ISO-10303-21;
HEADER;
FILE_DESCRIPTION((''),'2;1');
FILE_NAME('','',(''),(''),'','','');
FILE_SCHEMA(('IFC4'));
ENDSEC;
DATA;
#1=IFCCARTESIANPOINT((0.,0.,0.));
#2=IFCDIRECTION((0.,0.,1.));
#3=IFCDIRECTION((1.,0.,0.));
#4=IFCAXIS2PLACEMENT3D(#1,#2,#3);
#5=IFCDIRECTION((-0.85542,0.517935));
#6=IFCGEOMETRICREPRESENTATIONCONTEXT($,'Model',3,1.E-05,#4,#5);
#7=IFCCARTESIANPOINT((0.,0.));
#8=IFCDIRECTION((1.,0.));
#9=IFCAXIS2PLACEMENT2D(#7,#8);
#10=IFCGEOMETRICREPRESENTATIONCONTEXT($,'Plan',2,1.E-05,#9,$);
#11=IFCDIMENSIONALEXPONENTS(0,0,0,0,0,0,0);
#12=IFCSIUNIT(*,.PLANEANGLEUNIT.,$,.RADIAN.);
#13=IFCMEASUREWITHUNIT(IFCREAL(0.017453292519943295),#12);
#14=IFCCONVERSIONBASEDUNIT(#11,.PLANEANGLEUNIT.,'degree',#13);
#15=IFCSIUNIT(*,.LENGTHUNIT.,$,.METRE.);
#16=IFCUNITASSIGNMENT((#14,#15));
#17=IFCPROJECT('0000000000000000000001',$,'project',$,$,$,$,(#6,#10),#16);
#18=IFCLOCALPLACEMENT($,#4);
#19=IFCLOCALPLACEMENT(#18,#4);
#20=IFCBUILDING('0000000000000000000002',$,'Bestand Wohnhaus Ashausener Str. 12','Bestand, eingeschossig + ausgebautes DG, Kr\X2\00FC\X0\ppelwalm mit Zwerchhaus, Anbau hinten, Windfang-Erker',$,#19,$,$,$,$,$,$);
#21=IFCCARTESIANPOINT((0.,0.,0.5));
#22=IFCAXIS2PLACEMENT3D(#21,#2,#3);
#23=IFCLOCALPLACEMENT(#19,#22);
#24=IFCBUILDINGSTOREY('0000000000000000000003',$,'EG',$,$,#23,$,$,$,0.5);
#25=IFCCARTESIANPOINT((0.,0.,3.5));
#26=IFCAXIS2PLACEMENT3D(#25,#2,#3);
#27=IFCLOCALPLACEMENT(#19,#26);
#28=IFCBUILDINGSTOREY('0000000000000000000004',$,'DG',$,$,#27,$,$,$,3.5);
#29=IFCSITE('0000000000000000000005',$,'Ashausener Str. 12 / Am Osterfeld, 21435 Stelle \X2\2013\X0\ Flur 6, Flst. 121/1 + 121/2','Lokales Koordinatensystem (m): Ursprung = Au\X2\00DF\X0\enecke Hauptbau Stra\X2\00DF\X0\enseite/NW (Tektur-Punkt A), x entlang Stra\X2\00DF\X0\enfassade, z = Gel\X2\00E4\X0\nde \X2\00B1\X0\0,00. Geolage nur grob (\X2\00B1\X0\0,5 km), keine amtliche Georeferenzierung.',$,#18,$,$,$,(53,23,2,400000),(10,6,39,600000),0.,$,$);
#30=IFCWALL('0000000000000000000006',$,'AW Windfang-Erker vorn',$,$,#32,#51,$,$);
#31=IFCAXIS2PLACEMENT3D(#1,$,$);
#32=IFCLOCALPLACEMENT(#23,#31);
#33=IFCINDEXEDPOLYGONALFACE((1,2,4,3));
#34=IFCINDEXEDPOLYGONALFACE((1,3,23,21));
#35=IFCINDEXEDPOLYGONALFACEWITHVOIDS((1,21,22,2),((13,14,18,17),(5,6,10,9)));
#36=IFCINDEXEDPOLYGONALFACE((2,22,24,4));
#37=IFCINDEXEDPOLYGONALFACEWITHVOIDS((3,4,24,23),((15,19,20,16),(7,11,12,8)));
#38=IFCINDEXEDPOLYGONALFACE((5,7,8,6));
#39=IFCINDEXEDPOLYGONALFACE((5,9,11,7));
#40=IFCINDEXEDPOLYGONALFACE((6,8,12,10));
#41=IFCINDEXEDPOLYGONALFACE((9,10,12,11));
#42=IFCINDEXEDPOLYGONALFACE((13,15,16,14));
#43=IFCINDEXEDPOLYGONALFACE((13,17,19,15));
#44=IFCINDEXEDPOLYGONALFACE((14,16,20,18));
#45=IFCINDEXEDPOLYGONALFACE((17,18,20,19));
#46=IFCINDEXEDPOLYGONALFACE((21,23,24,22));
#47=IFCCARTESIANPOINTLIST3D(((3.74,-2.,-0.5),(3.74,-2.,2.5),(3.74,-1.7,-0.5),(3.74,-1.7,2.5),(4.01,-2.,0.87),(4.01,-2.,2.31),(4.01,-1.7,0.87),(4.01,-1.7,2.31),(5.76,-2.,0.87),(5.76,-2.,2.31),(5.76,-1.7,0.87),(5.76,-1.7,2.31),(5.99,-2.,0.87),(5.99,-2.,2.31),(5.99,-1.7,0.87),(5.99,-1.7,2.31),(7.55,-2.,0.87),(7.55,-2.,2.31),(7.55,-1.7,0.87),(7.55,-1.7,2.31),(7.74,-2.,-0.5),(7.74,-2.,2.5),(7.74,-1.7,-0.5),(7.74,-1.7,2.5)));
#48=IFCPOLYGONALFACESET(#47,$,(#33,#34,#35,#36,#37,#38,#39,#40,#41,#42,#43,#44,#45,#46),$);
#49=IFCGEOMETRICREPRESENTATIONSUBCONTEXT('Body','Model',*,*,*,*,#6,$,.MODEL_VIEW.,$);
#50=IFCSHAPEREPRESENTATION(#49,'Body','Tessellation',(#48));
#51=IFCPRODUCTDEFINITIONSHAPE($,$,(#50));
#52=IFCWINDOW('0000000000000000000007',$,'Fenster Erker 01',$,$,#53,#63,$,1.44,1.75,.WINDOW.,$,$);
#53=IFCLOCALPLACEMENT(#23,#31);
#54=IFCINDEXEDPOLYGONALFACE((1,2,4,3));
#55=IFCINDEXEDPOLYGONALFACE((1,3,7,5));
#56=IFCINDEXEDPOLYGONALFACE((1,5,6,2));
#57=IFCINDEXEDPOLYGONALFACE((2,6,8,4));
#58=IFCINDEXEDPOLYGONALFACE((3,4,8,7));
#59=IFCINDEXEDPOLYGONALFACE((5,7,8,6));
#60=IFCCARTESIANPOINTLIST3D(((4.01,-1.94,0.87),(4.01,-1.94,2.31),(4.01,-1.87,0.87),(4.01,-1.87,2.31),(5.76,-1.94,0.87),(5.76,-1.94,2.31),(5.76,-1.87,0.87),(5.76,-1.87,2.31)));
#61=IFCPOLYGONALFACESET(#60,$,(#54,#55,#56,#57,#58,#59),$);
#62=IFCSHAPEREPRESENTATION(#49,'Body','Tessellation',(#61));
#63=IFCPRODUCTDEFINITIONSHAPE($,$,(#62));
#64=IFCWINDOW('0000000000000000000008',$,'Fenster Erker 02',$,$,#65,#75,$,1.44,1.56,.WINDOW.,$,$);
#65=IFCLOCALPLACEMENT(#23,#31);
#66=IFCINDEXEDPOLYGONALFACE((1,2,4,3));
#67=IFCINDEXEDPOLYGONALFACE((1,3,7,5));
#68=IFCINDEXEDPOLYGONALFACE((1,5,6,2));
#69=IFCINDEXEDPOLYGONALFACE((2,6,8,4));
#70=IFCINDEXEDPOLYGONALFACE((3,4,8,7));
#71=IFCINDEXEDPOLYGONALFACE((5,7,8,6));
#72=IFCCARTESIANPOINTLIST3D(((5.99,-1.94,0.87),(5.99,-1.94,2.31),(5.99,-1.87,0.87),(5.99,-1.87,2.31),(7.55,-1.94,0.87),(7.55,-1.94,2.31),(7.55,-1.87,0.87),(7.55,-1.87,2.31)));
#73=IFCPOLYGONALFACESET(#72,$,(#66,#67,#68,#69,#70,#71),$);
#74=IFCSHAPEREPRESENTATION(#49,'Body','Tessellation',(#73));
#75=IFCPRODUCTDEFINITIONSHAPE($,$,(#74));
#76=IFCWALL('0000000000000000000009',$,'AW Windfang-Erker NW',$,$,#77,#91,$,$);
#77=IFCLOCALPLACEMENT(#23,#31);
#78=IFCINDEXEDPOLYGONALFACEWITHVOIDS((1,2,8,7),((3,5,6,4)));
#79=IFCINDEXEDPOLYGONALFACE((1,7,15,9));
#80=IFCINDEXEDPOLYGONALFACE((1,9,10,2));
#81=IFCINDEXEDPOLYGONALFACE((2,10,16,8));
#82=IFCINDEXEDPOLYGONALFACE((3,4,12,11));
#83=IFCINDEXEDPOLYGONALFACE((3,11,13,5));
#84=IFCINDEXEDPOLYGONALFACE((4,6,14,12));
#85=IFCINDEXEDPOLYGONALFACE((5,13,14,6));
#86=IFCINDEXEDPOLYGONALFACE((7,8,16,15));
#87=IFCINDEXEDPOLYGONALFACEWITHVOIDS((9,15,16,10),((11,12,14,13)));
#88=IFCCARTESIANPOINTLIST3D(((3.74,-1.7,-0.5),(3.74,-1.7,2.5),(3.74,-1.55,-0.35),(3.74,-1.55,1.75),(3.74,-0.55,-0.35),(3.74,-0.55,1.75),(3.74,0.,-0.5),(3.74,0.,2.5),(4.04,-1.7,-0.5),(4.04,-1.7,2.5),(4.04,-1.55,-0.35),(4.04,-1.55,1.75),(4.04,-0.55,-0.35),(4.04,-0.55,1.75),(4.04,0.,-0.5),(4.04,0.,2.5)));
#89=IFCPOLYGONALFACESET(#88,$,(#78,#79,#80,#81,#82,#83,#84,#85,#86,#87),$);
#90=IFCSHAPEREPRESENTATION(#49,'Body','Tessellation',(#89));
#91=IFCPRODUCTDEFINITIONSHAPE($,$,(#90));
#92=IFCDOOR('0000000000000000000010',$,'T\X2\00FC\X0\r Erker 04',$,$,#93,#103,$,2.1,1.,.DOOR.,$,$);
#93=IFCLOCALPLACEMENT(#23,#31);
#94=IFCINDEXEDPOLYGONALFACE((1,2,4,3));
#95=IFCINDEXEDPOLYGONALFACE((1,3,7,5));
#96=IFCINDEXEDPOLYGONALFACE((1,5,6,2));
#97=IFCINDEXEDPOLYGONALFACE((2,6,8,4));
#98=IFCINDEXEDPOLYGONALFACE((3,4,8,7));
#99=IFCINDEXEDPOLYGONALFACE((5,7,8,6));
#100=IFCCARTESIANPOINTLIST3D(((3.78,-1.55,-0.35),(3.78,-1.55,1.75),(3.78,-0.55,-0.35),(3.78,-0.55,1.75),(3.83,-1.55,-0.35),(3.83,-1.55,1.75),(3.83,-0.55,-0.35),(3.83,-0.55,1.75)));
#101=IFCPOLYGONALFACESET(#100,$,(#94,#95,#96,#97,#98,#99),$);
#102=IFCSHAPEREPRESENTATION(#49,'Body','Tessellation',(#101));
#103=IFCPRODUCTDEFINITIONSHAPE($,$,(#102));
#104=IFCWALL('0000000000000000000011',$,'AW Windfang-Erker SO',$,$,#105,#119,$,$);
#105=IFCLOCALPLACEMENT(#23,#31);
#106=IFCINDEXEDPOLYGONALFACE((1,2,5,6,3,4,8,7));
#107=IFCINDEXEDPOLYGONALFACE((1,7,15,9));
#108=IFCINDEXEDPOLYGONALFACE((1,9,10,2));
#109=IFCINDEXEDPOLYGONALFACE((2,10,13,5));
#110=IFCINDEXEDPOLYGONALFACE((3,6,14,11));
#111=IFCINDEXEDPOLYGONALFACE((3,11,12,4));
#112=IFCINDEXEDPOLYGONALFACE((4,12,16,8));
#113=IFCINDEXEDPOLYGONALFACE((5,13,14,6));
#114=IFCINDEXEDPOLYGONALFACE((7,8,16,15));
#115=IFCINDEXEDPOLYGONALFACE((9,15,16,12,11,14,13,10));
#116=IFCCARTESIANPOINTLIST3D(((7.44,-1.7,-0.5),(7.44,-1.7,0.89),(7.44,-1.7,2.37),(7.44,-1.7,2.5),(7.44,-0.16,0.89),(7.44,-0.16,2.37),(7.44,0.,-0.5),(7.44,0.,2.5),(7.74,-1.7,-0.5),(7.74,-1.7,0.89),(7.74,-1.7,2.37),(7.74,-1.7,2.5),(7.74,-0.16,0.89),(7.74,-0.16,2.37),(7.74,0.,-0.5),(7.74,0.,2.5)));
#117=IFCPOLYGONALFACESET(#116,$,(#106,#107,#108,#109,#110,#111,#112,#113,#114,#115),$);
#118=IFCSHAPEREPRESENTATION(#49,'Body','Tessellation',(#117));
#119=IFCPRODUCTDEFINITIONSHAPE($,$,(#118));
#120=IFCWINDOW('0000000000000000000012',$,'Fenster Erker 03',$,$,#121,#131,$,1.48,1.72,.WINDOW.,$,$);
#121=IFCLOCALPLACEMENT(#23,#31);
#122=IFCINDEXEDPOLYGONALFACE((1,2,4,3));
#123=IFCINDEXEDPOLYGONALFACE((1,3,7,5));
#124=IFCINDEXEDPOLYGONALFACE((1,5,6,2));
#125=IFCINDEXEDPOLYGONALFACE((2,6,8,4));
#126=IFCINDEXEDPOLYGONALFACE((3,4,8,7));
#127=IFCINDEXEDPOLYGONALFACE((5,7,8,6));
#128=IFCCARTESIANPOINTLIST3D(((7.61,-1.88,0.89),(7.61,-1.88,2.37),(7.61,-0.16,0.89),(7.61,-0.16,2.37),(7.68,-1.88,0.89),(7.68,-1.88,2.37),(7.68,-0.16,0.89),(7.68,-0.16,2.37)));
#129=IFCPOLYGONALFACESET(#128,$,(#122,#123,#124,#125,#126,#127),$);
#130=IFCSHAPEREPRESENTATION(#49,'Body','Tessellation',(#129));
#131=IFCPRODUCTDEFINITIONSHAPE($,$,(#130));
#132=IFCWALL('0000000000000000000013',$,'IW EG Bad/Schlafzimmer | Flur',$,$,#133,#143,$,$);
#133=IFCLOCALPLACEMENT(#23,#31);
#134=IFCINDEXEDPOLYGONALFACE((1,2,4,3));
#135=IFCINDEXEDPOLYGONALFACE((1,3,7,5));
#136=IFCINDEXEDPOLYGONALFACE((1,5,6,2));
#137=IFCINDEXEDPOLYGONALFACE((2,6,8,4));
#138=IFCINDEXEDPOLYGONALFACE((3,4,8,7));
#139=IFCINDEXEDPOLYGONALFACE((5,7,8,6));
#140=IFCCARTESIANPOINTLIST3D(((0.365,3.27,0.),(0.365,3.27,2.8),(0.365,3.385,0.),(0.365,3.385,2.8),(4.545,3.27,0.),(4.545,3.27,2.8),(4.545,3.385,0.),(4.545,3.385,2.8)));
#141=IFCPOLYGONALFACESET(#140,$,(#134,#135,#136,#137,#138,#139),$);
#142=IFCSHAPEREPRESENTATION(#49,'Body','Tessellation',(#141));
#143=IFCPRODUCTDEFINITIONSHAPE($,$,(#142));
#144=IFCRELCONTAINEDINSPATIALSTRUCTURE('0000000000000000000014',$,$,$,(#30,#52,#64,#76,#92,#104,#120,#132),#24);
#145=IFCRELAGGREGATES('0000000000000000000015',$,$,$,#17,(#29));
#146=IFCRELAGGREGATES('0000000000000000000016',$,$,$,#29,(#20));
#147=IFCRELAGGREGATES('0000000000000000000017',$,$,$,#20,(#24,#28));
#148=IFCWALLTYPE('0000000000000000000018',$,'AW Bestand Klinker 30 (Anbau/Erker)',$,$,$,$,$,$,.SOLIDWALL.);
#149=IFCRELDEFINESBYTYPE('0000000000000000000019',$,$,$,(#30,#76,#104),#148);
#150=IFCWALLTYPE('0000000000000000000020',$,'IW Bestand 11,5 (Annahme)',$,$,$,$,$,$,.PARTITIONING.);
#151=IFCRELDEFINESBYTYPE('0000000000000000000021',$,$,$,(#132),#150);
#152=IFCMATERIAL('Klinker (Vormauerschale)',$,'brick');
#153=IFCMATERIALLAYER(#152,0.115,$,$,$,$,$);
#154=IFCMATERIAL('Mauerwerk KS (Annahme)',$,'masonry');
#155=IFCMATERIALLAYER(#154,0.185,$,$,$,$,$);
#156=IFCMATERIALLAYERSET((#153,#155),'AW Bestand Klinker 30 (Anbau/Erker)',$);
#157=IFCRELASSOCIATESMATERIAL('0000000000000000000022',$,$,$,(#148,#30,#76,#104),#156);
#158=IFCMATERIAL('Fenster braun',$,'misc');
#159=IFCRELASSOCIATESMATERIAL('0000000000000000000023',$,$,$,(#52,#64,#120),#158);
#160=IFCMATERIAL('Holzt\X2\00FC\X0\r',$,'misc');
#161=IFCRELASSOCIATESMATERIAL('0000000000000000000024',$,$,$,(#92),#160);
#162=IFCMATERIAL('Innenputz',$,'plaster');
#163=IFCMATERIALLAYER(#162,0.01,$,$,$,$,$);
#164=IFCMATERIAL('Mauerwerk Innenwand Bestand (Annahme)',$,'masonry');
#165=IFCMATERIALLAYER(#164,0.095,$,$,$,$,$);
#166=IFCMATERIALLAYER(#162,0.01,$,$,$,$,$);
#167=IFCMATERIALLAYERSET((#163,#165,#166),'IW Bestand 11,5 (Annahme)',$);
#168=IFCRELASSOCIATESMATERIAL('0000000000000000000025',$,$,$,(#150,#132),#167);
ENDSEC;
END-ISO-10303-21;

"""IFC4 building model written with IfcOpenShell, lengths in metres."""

from ifc_helpers import new_model, entity, si_unit, converted_unit, direction, frame, origin_with_axes, origin_2d_with_axis, place, context, subcontext, project, spatial, indexed_curve, outline, extrude, material, layer, layer_set, layer_usage, type_object, element, fill, save


model = new_model("IFC4")

# Units and contexts
model_context = context("Model", 3, precision=1e-05, world=origin_with_axes(), true_north=direction((-0.85542, 0.517935)))
plan_context = context("Plan", 2, precision=1e-05, world=origin_2d_with_axis())
body_context = subcontext(model_context, "Body", "Model", "MODEL_VIEW")
ifc_project = project(units=[converted_unit("PLANEANGLEUNIT", "degree", entity("IfcReal", 0.017453292519943295), si_unit("PLANEANGLEUNIT", "RADIAN"), dimensions=[0, 0, 0, 0, 0, 0, 0]), si_unit("LENGTHUNIT", "METRE")], contexts=[model_context, plan_context])

# Site, building, storey
site_placement = place(None, origin_with_axes())
site = spatial("IfcSite", under=ifc_project, at=site_placement, Name="Ashausener Str. 12 / Am Osterfeld, 21435 Stelle – Flur 6, Flst. 121/1 + 121/2", Description="Lokales Koordinatensystem (m): Ursprung = Außenecke Hauptbau Straßenseite/NW (Tektur-Punkt A), x entlang Straßenfassade, z = Gelände ±0,00. Geolage nur grob (±0,5 km), keine amtliche Georeferenzierung.", RefLatitude=(53, 23, 2, 400000), RefLongitude=(10, 6, 39, 600000), RefElevation=0.0)
building_placement = place(site_placement, origin_with_axes())
building = spatial("IfcBuilding", under=site, at=building_placement, Name="Bestand Wohnhaus Ashausener Str. 12", Description="Bestand, eingeschossig + ausgebautes DG, Krüppelwalm mit Zwerchhaus, Anbau hinten, Windfang-Erker")
storey_1_placement = place(building_placement, frame((0.0, 0.0, 0.5), z_axis=(0.0, 0.0, 1.0), x_axis=(1.0, 0.0, 0.0)))
storey_1 = spatial("IfcBuildingStorey", under=building, at=storey_1_placement, Name="EG", Elevation=0.5)

# Shared definitions
ifc_material_1 = material(Name="Klinker (Vormauerschale)", Category="brick")
ifc_material_2 = material(Name="Mauerwerk KS (Annahme)", Category="masonry")

# Shared definitions
storey_2_placement = place(building_placement, frame((0.0, 0.0, 3.5), z_axis=(0.0, 0.0, 1.0), x_axis=(1.0, 0.0, 0.0)))
storey_2 = spatial("IfcBuildingStorey", under=building, at=storey_2_placement, Name="DG", Elevation=3.5)

# Wall, openings, windows
ifc_layer_1 = layer(ifc_material_1, 0.115)
ifc_layer_2 = layer(ifc_material_2, 0.185)
ifc_layer_set_1 = layer_set([ifc_layer_1, ifc_layer_2], Name="AW Bestand Klinker 30 (Anbau/Erker)")
ifc_layer_usage_1 = layer_usage(ifc_layer_set_1, "AXIS2", "POSITIVE", 0.0)
wall_type_1 = type_object("IfcWallType", Name="AW Bestand Klinker 30 (Anbau/Erker)", PredefinedType="SOLIDWALL", material=ifc_layer_set_1)
wall_1_placement = place(storey_1_placement, frame((3.74, -2.0, -0.5), z_axis=(0.0, 0.0, 1.0), x_axis=(1.0, 0.0, 0.0)))
wall_1 = element("IfcWall", 1, at=wall_1_placement, inside=storey_1, type_object=wall_type_1, material=ifc_layer_usage_1, Name="AW Windfang-Erker vorn", context=body_context, shape_type="SweptSolid", body=[
    extrude(outline(indexed_curve([(0.0, 0.0), (0.0, 0.3), (4.0, 0.3), (4.0, 0.0), (0.0, 0.0)], self_intersect=False)), origin_with_axes(), (0.0, 0.0, 1.0), 3.0),
])
opening_1_placement = place(wall_1_placement, frame((0.27, -0.1, 1.37), z_axis=(0.0, 0.0, 1.0), x_axis=(1.0, 0.0, 0.0)))
opening_1 = element("IfcOpeningElement", 2, at=opening_1_placement, cuts=wall_1, context=body_context, shape_type="SweptSolid", body=[
    extrude(outline(indexed_curve([(0.0, 0.0), (0.0, 0.5), (1.75, 0.5), (1.75, 0.0), (0.0, 0.0)], self_intersect=False)), origin_with_axes(), (0.0, 0.0, 1.0), 1.44),
])
opening_2_placement = place(wall_1_placement, frame((2.25, -0.1, 1.37), z_axis=(0.0, 0.0, 1.0), x_axis=(1.0, 0.0, 0.0)))
opening_2 = element("IfcOpeningElement", 3, at=opening_2_placement, cuts=wall_1, context=body_context, shape_type="SweptSolid", body=[
    extrude(outline(indexed_curve([(0.0, 0.0), (0.0, 0.5), (1.56, 0.5), (1.56, 0.0), (0.0, 0.0)], self_intersect=False)), origin_with_axes(), (0.0, 0.0, 1.0), 1.44),
])
ifc_material_3 = material(Name="Fenster braun", Category="misc")
window_1_placement = place(storey_1_placement, frame((4.01, -1.94, 0.87), z_axis=(0.0, 0.0, 1.0), x_axis=(1.0, 0.0, 0.0)))
window_1 = element("IfcWindow", 4, at=window_1_placement, inside=storey_1, material=ifc_material_3, Name="Fenster Erker 01", OverallHeight=1.44, OverallWidth=1.75, PredefinedType="WINDOW", context=body_context, shape_type="SweptSolid", body=[
    extrude(outline(indexed_curve([(0.0, 0.0), (0.0, 0.07), (1.75, 0.07), (1.75, 0.0), (0.0, 0.0)], self_intersect=False)), origin_with_axes(), (0.0, 0.0, 1.0), 1.44),
])
fill(opening_1, window_1)
window_2_placement = place(storey_1_placement, frame((5.99, -1.94, 0.87), z_axis=(0.0, 0.0, 1.0), x_axis=(1.0, 0.0, 0.0)))
window_2 = element("IfcWindow", 5, at=window_2_placement, inside=storey_1, material=ifc_material_3, Name="Fenster Erker 02", OverallHeight=1.44, OverallWidth=1.56, PredefinedType="WINDOW", context=body_context, shape_type="SweptSolid", body=[
    extrude(outline(indexed_curve([(0.0, 0.0), (0.0, 0.07), (1.56, 0.07), (1.56, 0.0), (0.0, 0.0)], self_intersect=False)), origin_with_axes(), (0.0, 0.0, 1.0), 1.44),
])
fill(opening_2, window_2)

# Wall, opening, door
ifc_layer_usage_2 = layer_usage(ifc_layer_set_1, "AXIS2", "POSITIVE", 0.0)
wall_2_placement = place(storey_1_placement, frame((3.74, 0.0, -0.5), z_axis=(0.0, 0.0, 1.0), x_axis=(0.0, -1.0, 0.0)))
wall_2 = element("IfcWall", 6, at=wall_2_placement, inside=storey_1, type_object=wall_type_1, material=ifc_layer_usage_2, Name="AW Windfang-Erker NW", context=body_context, shape_type="SweptSolid", body=[
    extrude(outline(indexed_curve([(0.0, 0.0), (0.0, 0.3), (1.7, 0.3), (1.7, 0.0), (0.0, 0.0)], self_intersect=False)), origin_with_axes(), (0.0, 0.0, 1.0), 3.0),
])
opening_3_placement = place(wall_2_placement, frame((0.55, -0.1, 0.15), z_axis=(0.0, 0.0, 1.0), x_axis=(1.0, 0.0, 0.0)))
opening_3 = element("IfcOpeningElement", 7, at=opening_3_placement, cuts=wall_2, context=body_context, shape_type="SweptSolid", body=[
    extrude(outline(indexed_curve([(0.0, 0.0), (0.0, 0.5), (1.0, 0.5), (1.0, 0.0), (0.0, 0.0)], self_intersect=False)), origin_with_axes(), (0.0, 0.0, 1.0), 2.1),
])
ifc_material_4 = material(Name="Holztür", Category="misc")
door_placement = place(storey_1_placement, frame((3.78, -0.55, -0.35), z_axis=(0.0, 0.0, 1.0), x_axis=(0.0, -1.0, 0.0)))
door = element("IfcDoor", 8, at=door_placement, inside=storey_1, material=ifc_material_4, Name="Tür Erker 04", OverallHeight=2.1, OverallWidth=1.0, PredefinedType="DOOR", context=body_context, shape_type="SweptSolid", body=[
    extrude(outline(indexed_curve([(0.0, 0.0), (0.0, 0.05), (1.0, 0.05), (1.0, 0.0), (0.0, 0.0)], self_intersect=False)), origin_with_axes(), (0.0, 0.0, 1.0), 2.1),
])
fill(opening_3, door)

# Wall, opening, window
ifc_layer_usage_3 = layer_usage(ifc_layer_set_1, "AXIS2", "POSITIVE", 0.0)
wall_3_placement = place(storey_1_placement, frame((7.74, -1.7, -0.5), z_axis=(0.0, 0.0, 1.0), x_axis=(0.0, 1.0, 0.0)))
wall_3 = element("IfcWall", 9, at=wall_3_placement, inside=storey_1, type_object=wall_type_1, material=ifc_layer_usage_3, Name="AW Windfang-Erker SO", context=body_context, shape_type="SweptSolid", body=[
    extrude(outline(indexed_curve([(0.0, 0.0), (0.0, 0.3), (1.7, 0.3), (1.7, 0.0), (0.0, 0.0)], self_intersect=False)), origin_with_axes(), (0.0, 0.0, 1.0), 3.0),
])
opening_4_placement = place(wall_3_placement, frame((-0.18, -0.1, 1.39), z_axis=(0.0, 0.0, 1.0), x_axis=(1.0, 0.0, 0.0)))
opening_4 = element("IfcOpeningElement", 10, at=opening_4_placement, cuts=wall_3, context=body_context, shape_type="SweptSolid", body=[
    extrude(outline(indexed_curve([(0.0, 0.0), (0.0, 0.5), (1.72, 0.5), (1.72, 0.0), (0.0, 0.0)], self_intersect=False)), origin_with_axes(), (0.0, 0.0, 1.0), 1.48),
])
window_3_placement = place(storey_1_placement, frame((7.68, -1.88, 0.89), z_axis=(0.0, 0.0, 1.0), x_axis=(0.0, 1.0, 0.0)))
window_3 = element("IfcWindow", 11, at=window_3_placement, inside=storey_1, material=ifc_material_3, Name="Fenster Erker 03", OverallHeight=1.48, OverallWidth=1.72, PredefinedType="WINDOW", context=body_context, shape_type="SweptSolid", body=[
    extrude(outline(indexed_curve([(0.0, 0.0), (0.0, 0.07), (1.72, 0.07), (1.72, 0.0), (0.0, 0.0)], self_intersect=False)), origin_with_axes(), (0.0, 0.0, 1.0), 1.48),
])
fill(opening_4, window_3)

# Wall
ifc_material_5 = material(Name="Innenputz", Category="plaster")
ifc_layer_3 = layer(ifc_material_5, 0.01)
ifc_material_6 = material(Name="Mauerwerk Innenwand Bestand (Annahme)", Category="masonry")
ifc_layer_4 = layer(ifc_material_6, 0.095)
ifc_layer_5 = layer(ifc_material_5, 0.01)
ifc_layer_set_2 = layer_set([ifc_layer_3, ifc_layer_4, ifc_layer_5], Name="IW Bestand 11,5 (Annahme)")
ifc_layer_usage_4 = layer_usage(ifc_layer_set_2, "AXIS2", "POSITIVE", 0.0)
wall_type_2 = type_object("IfcWallType", Name="IW Bestand 11,5 (Annahme)", PredefinedType="PARTITIONING", material=ifc_layer_set_2)
wall_4_placement = place(storey_1_placement, frame((0.365, 3.27, 0.0), z_axis=(0.0, 0.0, 1.0), x_axis=(1.0, 0.0, 0.0)))
element("IfcWall", 12, at=wall_4_placement, inside=storey_1, type_object=wall_type_2, material=ifc_layer_usage_4, Name="IW EG Bad/Schlafzimmer | Flur", context=body_context, shape_type="SweptSolid", body=[
    extrude(outline(indexed_curve([(0.0, 0.0), (0.0, 0.115), (4.18, 0.115), (4.18, 0.0), (0.0, 0.0)], self_intersect=False)), origin_with_axes(), (0.0, 0.0, 1.0), 2.8),
])

save(model, "model.ifc")
